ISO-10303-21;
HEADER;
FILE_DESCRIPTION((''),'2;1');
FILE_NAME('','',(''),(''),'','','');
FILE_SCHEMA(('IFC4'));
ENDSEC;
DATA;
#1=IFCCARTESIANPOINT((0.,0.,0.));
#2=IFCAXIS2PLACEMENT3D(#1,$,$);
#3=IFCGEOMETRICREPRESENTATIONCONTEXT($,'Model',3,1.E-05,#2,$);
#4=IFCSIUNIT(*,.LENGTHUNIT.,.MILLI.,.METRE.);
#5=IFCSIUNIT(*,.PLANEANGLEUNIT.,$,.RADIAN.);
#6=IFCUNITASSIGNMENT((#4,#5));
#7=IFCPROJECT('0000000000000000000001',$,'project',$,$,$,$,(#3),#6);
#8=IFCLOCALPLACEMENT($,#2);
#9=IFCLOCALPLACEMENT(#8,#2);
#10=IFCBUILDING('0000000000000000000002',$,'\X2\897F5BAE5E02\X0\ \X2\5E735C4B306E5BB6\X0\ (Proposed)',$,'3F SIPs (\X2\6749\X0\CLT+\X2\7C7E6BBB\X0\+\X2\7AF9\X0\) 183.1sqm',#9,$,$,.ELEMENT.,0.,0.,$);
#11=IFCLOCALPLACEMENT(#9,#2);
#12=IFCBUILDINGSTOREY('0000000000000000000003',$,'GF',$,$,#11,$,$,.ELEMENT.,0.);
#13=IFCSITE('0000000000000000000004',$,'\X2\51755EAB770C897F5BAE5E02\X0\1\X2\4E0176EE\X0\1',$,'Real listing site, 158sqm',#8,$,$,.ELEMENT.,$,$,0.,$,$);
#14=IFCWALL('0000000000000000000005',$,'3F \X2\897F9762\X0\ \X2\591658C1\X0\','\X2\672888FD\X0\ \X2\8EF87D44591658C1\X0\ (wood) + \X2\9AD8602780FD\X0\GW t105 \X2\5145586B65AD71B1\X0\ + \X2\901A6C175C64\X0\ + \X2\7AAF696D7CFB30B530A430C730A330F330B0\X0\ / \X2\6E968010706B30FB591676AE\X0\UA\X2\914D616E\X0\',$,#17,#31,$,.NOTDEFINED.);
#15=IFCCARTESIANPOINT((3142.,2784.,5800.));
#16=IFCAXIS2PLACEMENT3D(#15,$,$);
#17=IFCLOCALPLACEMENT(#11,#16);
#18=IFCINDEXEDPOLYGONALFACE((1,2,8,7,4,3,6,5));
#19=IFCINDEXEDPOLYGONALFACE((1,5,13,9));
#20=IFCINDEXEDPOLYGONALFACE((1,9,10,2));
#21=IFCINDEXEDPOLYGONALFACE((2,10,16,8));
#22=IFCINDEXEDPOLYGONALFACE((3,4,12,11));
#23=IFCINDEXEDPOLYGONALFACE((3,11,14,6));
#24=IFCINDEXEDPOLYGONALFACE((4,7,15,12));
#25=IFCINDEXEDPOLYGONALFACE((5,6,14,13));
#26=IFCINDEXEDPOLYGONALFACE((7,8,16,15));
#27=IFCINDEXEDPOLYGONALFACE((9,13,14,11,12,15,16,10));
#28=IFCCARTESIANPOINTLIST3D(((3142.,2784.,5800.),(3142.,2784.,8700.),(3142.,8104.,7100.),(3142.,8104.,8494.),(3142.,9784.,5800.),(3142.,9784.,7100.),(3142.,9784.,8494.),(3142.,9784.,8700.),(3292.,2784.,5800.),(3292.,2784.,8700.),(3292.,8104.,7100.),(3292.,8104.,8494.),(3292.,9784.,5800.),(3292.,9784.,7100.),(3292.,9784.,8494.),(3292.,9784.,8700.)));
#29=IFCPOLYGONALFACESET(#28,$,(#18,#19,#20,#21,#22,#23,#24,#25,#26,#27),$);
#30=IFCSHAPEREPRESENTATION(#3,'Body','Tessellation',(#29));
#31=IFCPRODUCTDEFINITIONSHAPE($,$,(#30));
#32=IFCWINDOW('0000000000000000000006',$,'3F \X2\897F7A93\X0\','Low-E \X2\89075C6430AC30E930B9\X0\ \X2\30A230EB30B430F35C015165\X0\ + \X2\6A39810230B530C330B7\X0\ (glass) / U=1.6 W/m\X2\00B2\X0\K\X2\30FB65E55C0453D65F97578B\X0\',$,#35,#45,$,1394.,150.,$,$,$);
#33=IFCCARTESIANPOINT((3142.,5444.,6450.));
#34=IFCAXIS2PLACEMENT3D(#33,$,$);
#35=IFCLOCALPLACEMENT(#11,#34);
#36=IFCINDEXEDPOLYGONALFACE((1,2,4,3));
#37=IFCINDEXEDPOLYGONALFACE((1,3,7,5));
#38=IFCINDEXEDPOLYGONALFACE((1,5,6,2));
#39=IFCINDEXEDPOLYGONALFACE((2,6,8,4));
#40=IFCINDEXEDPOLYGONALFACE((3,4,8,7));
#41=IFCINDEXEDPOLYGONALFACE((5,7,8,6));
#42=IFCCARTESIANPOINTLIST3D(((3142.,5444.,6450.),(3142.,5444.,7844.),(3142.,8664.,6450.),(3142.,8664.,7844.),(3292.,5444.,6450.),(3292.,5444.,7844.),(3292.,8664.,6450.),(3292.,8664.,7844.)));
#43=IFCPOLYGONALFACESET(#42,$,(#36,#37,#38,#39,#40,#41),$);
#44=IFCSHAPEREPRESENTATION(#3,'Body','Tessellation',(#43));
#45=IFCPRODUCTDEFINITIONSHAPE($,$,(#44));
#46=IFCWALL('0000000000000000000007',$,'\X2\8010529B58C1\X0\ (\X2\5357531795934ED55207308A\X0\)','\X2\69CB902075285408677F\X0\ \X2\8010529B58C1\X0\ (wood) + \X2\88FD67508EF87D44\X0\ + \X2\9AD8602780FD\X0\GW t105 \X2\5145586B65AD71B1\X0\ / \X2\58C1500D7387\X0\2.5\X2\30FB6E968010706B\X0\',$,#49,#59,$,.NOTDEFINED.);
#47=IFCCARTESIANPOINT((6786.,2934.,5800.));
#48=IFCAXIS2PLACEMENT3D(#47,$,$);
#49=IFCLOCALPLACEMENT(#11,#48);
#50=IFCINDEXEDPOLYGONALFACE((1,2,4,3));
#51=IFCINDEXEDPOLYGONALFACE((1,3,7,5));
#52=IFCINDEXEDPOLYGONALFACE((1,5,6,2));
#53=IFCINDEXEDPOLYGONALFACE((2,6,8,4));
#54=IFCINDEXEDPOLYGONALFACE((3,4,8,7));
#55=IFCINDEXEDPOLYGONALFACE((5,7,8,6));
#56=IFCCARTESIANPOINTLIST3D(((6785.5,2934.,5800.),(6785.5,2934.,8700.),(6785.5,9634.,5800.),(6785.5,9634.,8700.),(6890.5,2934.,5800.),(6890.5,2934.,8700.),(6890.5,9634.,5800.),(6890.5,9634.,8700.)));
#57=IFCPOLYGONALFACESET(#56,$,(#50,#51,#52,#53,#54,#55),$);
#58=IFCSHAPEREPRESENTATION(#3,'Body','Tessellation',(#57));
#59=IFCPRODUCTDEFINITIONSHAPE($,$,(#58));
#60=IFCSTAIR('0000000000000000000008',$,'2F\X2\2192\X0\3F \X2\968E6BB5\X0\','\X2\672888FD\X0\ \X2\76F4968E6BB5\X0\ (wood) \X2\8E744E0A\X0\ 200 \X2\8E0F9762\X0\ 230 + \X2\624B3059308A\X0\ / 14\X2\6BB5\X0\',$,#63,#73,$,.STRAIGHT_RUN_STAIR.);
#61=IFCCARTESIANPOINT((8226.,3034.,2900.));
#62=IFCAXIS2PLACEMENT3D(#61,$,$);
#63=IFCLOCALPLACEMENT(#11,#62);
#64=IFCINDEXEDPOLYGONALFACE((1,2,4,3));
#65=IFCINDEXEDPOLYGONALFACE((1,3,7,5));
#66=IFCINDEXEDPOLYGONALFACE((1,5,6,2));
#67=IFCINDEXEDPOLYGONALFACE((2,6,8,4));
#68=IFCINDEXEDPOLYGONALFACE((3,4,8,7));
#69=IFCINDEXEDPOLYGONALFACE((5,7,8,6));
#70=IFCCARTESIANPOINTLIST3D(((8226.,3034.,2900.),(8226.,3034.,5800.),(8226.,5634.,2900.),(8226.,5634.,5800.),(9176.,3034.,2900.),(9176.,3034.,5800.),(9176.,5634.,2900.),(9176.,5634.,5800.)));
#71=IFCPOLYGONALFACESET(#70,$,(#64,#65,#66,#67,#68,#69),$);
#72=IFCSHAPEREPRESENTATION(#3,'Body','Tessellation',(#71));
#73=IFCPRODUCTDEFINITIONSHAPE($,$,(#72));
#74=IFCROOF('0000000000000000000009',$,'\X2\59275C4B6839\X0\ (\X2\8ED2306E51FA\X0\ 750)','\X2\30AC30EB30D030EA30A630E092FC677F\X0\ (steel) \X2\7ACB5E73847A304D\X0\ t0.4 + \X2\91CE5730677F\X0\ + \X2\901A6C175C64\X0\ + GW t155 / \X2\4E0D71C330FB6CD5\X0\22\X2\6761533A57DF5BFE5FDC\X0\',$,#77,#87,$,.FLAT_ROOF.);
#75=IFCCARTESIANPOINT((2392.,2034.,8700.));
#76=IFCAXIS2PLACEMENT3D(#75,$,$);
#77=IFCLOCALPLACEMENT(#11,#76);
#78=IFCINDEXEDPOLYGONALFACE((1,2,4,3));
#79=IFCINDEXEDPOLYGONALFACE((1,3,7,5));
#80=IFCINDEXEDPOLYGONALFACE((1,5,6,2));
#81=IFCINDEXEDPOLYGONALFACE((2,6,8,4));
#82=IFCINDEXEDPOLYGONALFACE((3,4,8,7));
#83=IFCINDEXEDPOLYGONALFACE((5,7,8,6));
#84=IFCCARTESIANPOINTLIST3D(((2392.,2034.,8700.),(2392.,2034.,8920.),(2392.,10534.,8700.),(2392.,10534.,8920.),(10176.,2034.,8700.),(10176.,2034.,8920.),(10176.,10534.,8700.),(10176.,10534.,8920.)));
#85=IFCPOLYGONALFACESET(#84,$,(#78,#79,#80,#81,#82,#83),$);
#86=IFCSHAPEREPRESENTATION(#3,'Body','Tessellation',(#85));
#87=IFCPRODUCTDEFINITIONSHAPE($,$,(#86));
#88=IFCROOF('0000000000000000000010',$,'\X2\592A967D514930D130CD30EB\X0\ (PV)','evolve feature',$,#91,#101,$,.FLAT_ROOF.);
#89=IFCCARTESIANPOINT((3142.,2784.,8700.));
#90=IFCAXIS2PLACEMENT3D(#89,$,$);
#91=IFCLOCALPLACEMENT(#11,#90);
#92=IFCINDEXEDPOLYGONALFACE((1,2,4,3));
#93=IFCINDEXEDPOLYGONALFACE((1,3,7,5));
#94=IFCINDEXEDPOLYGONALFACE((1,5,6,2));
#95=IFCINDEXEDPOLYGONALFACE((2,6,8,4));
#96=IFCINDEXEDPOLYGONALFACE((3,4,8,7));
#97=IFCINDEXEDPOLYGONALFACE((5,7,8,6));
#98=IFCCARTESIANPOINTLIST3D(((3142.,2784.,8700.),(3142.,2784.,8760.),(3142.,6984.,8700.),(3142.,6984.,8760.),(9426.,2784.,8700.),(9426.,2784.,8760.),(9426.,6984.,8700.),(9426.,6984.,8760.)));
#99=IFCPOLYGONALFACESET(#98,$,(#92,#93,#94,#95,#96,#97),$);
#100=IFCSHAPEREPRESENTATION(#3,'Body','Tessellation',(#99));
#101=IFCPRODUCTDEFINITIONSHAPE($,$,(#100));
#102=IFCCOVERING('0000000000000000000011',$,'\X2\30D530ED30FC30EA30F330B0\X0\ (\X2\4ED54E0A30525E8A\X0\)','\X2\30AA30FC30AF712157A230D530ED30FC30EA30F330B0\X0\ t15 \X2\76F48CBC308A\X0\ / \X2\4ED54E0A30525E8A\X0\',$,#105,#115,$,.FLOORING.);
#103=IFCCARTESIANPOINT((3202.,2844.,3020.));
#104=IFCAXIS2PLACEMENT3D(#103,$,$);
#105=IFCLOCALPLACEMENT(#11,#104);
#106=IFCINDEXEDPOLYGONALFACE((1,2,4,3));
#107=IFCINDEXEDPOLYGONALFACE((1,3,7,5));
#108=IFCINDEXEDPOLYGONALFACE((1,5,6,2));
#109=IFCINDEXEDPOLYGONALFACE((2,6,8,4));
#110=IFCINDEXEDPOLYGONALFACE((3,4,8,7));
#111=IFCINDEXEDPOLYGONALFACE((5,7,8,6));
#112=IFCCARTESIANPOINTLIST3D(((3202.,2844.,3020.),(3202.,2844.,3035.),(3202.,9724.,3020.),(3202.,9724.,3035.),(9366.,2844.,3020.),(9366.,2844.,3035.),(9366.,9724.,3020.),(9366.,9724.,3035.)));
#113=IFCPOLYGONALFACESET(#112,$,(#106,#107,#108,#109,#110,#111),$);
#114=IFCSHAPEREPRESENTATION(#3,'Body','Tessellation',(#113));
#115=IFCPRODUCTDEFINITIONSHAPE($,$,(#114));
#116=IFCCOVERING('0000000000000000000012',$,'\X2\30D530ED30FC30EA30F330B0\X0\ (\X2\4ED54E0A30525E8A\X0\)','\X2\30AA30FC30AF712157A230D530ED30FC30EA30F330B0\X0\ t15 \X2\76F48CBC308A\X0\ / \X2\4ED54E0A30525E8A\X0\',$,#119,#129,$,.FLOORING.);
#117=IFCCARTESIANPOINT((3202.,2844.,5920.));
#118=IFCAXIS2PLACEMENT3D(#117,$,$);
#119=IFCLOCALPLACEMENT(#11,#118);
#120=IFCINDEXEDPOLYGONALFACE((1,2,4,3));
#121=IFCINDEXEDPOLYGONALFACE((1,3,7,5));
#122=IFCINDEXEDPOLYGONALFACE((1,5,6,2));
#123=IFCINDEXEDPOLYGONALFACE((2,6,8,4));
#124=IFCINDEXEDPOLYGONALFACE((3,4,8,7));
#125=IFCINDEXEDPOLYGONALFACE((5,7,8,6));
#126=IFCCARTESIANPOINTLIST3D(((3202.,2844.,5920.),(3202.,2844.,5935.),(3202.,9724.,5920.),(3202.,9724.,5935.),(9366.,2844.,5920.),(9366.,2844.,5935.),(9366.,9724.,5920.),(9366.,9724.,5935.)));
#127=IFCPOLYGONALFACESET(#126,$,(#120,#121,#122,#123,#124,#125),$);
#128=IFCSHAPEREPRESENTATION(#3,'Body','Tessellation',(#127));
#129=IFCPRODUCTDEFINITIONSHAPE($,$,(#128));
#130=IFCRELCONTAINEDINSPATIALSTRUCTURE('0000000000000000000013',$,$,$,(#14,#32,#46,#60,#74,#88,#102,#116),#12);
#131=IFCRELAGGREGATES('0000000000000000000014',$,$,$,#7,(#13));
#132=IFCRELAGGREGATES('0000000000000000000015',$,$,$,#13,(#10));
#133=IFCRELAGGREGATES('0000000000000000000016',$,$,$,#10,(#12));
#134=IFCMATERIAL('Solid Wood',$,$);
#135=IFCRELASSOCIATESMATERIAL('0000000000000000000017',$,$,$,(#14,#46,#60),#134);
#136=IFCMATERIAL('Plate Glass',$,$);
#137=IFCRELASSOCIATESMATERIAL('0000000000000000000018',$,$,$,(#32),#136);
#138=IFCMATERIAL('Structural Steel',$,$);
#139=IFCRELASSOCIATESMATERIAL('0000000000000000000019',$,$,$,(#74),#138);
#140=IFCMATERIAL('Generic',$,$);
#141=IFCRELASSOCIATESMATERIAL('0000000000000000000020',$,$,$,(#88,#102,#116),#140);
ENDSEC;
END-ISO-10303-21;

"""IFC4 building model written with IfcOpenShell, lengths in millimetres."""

from ifc_helpers import new_model, si_unit, frame, frame_2d, origin, place, context, project, spatial, rectangle, extrude, material, element, fill, save


model = new_model("IFC4")

# Units and contexts
model_context = context("Model", 3, precision=1e-05, world=origin())
ifc_project = project(units=[si_unit("LENGTHUNIT", "METRE", prefix="MILLI"), si_unit("PLANEANGLEUNIT", "RADIAN")], contexts=[model_context])

# Site, building, storey
site_placement = place(None, origin())
site = spatial("IfcSite", under=ifc_project, at=site_placement, Name="兵庫県西宮市1丁目1", ObjectType="Real listing site, 158sqm", CompositionType="ELEMENT", RefElevation=0.0)
building_placement = place(site_placement, origin())
building = spatial("IfcBuilding", under=site, at=building_placement, Name="西宮市 平屋の家 (Proposed)", ObjectType="3F SIPs (杉CLT+籾殻+竹) 183.1sqm", CompositionType="ELEMENT", ElevationOfRefHeight=0.0, ElevationOfTerrain=0.0)
storey_placement = place(building_placement, origin())
storey = spatial("IfcBuildingStorey", under=building, at=storey_placement, Name="GF", CompositionType="ELEMENT", Elevation=0.0)

# Shared definitions
ifc_material_1 = material(Name="Solid Wood")

# Shared definitions
ifc_material_2 = material(Name="Plate Glass")

# Shared definitions
ifc_material_3 = material(Name="Generic")

# Wall, opening, window
wall_1_placement = place(storey_placement, frame((3142.0, 2784.0, 5800.0)))
wall_1 = element("IfcWall", 1, at=wall_1_placement, inside=storey, material=ifc_material_1, Name="3F 西面 外壁", Description="木製 軸組外壁 (wood) + 高性能GW t105 充填断熱 + 通気層 + 窯業系サイディング / 準耐火・外皮UA配慮", PredefinedType="NOTDEFINED", context=model_context, shape_type="SweptSolid", body=[
    extrude(rectangle(XDim=150.0, YDim=7000.0, at=frame_2d((75.0, 3500.0))), frame((3142.0, 2784.0, 5800.0)), (0.0, 0.0, 1.0), 2900.0),
])
opening_1_placement = place(storey_placement, frame((3142.0, 5444.0, 6450.0)))
opening_1 = element("IfcOpeningElement", 2, at=opening_1_placement, cuts=wall_1, PredefinedType="NOTDEFINED", context=model_context, shape_type="SweptSolid", body=[
    extrude(rectangle(XDim=150.0, YDim=3220.0, at=frame_2d((75.0, 1610.0))), frame((3142.0, 5444.0, 6450.0)), (0.0, 0.0, 1.0), 1394.0),
])
window_1_placement = place(storey_placement, frame((3142.0, 5444.0, 6450.0)))
window_1 = element("IfcWindow", 3, at=window_1_placement, inside=storey, material=ifc_material_2, Name="3F 西窓", Description="Low-E 複層ガラス アルゴン封入 + 樹脂サッシ (glass) / U=1.6 W/m²K・日射取得型", OverallHeight=1394.0, OverallWidth=150.0, context=model_context, shape_type="SweptSolid", body=[
    extrude(rectangle(XDim=150.0, YDim=3220.0, at=frame_2d((75.0, 1610.0))), frame((3142.0, 5444.0, 6450.0)), (0.0, 0.0, 1.0), 1394.0),
])
fill(opening_1, window_1)

# Wall
wall_2_placement = place(storey_placement, frame((6786.0, 2934.0, 5800.0)))
element("IfcWall", 4, at=wall_2_placement, inside=storey, material=ifc_material_1, Name="耐力壁 (南北間仕切り)", Description="構造用合板 耐力壁 (wood) + 製材軸組 + 高性能GW t105 充填断熱 / 壁倍率2.5・準耐火", PredefinedType="NOTDEFINED", context=model_context, shape_type="SweptSolid", body=[
    extrude(rectangle(XDim=105.0, YDim=6700.0, at=frame_2d((52.0, 3350.0))), frame((6786.0, 2934.0, 5800.0)), (0.0, 0.0, 1.0), 2900.0),
])

# Stair
stair_placement = place(storey_placement, frame((8226.0, 3034.0, 2900.0)))
element("IfcStair", 5, at=stair_placement, inside=storey, material=ifc_material_1, Name="2F→3F 階段", Description="木製 直階段 (wood) 蹴上 200 踏面 230 + 手すり / 14段", PredefinedType="STRAIGHT_RUN_STAIR", context=model_context, shape_type="SweptSolid", body=[
    extrude(rectangle(XDim=950.0, YDim=2600.0, at=frame_2d((475.0, 1300.0))), frame((8226.0, 3034.0, 2900.0)), (0.0, 0.0, 1.0), 2900.0),
])

# Roofs
ifc_material_4 = material(Name="Structural Steel")
roof_1_placement = place(storey_placement, frame((2392.0, 2034.0, 8700.0)))
element("IfcRoof", 6, at=roof_1_placement, inside=storey, material=ifc_material_4, Name="大屋根 (軒の出 750)", Description="ガルバリウム鋼板 (steel) 立平葺き t0.4 + 野地板 + 通気層 + GW t155 / 不燃・法22条区域対応", PredefinedType="FLAT_ROOF", context=model_context, shape_type="SweptSolid", body=[
    extrude(rectangle(XDim=7784.0, YDim=8500.0, at=frame_2d((3892.0, 4250.0))), frame((2392.0, 2034.0, 8700.0)), (0.0, 0.0, 1.0), 220.0),
])
roof_2_placement = place(storey_placement, frame((3142.0, 2784.0, 8700.0)))
element("IfcRoof", 7, at=roof_2_placement, inside=storey, material=ifc_material_3, Name="太陽光パネル (PV)", Description="evolve feature", PredefinedType="FLAT_ROOF", context=model_context, shape_type="SweptSolid", body=[
    extrude(rectangle(XDim=6284.0, YDim=4200.0, at=frame_2d((3142.0, 2100.0))), frame((3142.0, 2784.0, 8700.0)), (0.0, 0.0, 1.0), 60.0),
])

# Coverings
covering_1_placement = place(storey_placement, frame((3202.0, 2844.0, 3020.0)))
element("IfcCovering", 8, at=covering_1_placement, inside=storey, material=ifc_material_3, Name="フローリング (仕上げ床)", Description="オーク無垢フローリング t15 直貼り / 仕上げ床", PredefinedType="FLOORING", context=model_context, shape_type="SweptSolid", body=[
    extrude(rectangle(XDim=6164.0, YDim=6880.0, at=frame_2d((3082.0, 3440.0))), frame((3202.0, 2844.0, 3020.0)), (0.0, 0.0, 1.0), 15.0),
])
covering_2_placement = place(storey_placement, frame((3202.0, 2844.0, 5920.0)))
element("IfcCovering", 9, at=covering_2_placement, inside=storey, material=ifc_material_3, Name="フローリング (仕上げ床)", Description="オーク無垢フローリング t15 直貼り / 仕上げ床", PredefinedType="FLOORING", context=model_context, shape_type="SweptSolid", body=[
    extrude(rectangle(XDim=6164.0, YDim=6880.0, at=frame_2d((3082.0, 3440.0))), frame((3202.0, 2844.0, 5920.0)), (0.0, 0.0, 1.0), 15.0),
])

save(model, "model.ifc")
